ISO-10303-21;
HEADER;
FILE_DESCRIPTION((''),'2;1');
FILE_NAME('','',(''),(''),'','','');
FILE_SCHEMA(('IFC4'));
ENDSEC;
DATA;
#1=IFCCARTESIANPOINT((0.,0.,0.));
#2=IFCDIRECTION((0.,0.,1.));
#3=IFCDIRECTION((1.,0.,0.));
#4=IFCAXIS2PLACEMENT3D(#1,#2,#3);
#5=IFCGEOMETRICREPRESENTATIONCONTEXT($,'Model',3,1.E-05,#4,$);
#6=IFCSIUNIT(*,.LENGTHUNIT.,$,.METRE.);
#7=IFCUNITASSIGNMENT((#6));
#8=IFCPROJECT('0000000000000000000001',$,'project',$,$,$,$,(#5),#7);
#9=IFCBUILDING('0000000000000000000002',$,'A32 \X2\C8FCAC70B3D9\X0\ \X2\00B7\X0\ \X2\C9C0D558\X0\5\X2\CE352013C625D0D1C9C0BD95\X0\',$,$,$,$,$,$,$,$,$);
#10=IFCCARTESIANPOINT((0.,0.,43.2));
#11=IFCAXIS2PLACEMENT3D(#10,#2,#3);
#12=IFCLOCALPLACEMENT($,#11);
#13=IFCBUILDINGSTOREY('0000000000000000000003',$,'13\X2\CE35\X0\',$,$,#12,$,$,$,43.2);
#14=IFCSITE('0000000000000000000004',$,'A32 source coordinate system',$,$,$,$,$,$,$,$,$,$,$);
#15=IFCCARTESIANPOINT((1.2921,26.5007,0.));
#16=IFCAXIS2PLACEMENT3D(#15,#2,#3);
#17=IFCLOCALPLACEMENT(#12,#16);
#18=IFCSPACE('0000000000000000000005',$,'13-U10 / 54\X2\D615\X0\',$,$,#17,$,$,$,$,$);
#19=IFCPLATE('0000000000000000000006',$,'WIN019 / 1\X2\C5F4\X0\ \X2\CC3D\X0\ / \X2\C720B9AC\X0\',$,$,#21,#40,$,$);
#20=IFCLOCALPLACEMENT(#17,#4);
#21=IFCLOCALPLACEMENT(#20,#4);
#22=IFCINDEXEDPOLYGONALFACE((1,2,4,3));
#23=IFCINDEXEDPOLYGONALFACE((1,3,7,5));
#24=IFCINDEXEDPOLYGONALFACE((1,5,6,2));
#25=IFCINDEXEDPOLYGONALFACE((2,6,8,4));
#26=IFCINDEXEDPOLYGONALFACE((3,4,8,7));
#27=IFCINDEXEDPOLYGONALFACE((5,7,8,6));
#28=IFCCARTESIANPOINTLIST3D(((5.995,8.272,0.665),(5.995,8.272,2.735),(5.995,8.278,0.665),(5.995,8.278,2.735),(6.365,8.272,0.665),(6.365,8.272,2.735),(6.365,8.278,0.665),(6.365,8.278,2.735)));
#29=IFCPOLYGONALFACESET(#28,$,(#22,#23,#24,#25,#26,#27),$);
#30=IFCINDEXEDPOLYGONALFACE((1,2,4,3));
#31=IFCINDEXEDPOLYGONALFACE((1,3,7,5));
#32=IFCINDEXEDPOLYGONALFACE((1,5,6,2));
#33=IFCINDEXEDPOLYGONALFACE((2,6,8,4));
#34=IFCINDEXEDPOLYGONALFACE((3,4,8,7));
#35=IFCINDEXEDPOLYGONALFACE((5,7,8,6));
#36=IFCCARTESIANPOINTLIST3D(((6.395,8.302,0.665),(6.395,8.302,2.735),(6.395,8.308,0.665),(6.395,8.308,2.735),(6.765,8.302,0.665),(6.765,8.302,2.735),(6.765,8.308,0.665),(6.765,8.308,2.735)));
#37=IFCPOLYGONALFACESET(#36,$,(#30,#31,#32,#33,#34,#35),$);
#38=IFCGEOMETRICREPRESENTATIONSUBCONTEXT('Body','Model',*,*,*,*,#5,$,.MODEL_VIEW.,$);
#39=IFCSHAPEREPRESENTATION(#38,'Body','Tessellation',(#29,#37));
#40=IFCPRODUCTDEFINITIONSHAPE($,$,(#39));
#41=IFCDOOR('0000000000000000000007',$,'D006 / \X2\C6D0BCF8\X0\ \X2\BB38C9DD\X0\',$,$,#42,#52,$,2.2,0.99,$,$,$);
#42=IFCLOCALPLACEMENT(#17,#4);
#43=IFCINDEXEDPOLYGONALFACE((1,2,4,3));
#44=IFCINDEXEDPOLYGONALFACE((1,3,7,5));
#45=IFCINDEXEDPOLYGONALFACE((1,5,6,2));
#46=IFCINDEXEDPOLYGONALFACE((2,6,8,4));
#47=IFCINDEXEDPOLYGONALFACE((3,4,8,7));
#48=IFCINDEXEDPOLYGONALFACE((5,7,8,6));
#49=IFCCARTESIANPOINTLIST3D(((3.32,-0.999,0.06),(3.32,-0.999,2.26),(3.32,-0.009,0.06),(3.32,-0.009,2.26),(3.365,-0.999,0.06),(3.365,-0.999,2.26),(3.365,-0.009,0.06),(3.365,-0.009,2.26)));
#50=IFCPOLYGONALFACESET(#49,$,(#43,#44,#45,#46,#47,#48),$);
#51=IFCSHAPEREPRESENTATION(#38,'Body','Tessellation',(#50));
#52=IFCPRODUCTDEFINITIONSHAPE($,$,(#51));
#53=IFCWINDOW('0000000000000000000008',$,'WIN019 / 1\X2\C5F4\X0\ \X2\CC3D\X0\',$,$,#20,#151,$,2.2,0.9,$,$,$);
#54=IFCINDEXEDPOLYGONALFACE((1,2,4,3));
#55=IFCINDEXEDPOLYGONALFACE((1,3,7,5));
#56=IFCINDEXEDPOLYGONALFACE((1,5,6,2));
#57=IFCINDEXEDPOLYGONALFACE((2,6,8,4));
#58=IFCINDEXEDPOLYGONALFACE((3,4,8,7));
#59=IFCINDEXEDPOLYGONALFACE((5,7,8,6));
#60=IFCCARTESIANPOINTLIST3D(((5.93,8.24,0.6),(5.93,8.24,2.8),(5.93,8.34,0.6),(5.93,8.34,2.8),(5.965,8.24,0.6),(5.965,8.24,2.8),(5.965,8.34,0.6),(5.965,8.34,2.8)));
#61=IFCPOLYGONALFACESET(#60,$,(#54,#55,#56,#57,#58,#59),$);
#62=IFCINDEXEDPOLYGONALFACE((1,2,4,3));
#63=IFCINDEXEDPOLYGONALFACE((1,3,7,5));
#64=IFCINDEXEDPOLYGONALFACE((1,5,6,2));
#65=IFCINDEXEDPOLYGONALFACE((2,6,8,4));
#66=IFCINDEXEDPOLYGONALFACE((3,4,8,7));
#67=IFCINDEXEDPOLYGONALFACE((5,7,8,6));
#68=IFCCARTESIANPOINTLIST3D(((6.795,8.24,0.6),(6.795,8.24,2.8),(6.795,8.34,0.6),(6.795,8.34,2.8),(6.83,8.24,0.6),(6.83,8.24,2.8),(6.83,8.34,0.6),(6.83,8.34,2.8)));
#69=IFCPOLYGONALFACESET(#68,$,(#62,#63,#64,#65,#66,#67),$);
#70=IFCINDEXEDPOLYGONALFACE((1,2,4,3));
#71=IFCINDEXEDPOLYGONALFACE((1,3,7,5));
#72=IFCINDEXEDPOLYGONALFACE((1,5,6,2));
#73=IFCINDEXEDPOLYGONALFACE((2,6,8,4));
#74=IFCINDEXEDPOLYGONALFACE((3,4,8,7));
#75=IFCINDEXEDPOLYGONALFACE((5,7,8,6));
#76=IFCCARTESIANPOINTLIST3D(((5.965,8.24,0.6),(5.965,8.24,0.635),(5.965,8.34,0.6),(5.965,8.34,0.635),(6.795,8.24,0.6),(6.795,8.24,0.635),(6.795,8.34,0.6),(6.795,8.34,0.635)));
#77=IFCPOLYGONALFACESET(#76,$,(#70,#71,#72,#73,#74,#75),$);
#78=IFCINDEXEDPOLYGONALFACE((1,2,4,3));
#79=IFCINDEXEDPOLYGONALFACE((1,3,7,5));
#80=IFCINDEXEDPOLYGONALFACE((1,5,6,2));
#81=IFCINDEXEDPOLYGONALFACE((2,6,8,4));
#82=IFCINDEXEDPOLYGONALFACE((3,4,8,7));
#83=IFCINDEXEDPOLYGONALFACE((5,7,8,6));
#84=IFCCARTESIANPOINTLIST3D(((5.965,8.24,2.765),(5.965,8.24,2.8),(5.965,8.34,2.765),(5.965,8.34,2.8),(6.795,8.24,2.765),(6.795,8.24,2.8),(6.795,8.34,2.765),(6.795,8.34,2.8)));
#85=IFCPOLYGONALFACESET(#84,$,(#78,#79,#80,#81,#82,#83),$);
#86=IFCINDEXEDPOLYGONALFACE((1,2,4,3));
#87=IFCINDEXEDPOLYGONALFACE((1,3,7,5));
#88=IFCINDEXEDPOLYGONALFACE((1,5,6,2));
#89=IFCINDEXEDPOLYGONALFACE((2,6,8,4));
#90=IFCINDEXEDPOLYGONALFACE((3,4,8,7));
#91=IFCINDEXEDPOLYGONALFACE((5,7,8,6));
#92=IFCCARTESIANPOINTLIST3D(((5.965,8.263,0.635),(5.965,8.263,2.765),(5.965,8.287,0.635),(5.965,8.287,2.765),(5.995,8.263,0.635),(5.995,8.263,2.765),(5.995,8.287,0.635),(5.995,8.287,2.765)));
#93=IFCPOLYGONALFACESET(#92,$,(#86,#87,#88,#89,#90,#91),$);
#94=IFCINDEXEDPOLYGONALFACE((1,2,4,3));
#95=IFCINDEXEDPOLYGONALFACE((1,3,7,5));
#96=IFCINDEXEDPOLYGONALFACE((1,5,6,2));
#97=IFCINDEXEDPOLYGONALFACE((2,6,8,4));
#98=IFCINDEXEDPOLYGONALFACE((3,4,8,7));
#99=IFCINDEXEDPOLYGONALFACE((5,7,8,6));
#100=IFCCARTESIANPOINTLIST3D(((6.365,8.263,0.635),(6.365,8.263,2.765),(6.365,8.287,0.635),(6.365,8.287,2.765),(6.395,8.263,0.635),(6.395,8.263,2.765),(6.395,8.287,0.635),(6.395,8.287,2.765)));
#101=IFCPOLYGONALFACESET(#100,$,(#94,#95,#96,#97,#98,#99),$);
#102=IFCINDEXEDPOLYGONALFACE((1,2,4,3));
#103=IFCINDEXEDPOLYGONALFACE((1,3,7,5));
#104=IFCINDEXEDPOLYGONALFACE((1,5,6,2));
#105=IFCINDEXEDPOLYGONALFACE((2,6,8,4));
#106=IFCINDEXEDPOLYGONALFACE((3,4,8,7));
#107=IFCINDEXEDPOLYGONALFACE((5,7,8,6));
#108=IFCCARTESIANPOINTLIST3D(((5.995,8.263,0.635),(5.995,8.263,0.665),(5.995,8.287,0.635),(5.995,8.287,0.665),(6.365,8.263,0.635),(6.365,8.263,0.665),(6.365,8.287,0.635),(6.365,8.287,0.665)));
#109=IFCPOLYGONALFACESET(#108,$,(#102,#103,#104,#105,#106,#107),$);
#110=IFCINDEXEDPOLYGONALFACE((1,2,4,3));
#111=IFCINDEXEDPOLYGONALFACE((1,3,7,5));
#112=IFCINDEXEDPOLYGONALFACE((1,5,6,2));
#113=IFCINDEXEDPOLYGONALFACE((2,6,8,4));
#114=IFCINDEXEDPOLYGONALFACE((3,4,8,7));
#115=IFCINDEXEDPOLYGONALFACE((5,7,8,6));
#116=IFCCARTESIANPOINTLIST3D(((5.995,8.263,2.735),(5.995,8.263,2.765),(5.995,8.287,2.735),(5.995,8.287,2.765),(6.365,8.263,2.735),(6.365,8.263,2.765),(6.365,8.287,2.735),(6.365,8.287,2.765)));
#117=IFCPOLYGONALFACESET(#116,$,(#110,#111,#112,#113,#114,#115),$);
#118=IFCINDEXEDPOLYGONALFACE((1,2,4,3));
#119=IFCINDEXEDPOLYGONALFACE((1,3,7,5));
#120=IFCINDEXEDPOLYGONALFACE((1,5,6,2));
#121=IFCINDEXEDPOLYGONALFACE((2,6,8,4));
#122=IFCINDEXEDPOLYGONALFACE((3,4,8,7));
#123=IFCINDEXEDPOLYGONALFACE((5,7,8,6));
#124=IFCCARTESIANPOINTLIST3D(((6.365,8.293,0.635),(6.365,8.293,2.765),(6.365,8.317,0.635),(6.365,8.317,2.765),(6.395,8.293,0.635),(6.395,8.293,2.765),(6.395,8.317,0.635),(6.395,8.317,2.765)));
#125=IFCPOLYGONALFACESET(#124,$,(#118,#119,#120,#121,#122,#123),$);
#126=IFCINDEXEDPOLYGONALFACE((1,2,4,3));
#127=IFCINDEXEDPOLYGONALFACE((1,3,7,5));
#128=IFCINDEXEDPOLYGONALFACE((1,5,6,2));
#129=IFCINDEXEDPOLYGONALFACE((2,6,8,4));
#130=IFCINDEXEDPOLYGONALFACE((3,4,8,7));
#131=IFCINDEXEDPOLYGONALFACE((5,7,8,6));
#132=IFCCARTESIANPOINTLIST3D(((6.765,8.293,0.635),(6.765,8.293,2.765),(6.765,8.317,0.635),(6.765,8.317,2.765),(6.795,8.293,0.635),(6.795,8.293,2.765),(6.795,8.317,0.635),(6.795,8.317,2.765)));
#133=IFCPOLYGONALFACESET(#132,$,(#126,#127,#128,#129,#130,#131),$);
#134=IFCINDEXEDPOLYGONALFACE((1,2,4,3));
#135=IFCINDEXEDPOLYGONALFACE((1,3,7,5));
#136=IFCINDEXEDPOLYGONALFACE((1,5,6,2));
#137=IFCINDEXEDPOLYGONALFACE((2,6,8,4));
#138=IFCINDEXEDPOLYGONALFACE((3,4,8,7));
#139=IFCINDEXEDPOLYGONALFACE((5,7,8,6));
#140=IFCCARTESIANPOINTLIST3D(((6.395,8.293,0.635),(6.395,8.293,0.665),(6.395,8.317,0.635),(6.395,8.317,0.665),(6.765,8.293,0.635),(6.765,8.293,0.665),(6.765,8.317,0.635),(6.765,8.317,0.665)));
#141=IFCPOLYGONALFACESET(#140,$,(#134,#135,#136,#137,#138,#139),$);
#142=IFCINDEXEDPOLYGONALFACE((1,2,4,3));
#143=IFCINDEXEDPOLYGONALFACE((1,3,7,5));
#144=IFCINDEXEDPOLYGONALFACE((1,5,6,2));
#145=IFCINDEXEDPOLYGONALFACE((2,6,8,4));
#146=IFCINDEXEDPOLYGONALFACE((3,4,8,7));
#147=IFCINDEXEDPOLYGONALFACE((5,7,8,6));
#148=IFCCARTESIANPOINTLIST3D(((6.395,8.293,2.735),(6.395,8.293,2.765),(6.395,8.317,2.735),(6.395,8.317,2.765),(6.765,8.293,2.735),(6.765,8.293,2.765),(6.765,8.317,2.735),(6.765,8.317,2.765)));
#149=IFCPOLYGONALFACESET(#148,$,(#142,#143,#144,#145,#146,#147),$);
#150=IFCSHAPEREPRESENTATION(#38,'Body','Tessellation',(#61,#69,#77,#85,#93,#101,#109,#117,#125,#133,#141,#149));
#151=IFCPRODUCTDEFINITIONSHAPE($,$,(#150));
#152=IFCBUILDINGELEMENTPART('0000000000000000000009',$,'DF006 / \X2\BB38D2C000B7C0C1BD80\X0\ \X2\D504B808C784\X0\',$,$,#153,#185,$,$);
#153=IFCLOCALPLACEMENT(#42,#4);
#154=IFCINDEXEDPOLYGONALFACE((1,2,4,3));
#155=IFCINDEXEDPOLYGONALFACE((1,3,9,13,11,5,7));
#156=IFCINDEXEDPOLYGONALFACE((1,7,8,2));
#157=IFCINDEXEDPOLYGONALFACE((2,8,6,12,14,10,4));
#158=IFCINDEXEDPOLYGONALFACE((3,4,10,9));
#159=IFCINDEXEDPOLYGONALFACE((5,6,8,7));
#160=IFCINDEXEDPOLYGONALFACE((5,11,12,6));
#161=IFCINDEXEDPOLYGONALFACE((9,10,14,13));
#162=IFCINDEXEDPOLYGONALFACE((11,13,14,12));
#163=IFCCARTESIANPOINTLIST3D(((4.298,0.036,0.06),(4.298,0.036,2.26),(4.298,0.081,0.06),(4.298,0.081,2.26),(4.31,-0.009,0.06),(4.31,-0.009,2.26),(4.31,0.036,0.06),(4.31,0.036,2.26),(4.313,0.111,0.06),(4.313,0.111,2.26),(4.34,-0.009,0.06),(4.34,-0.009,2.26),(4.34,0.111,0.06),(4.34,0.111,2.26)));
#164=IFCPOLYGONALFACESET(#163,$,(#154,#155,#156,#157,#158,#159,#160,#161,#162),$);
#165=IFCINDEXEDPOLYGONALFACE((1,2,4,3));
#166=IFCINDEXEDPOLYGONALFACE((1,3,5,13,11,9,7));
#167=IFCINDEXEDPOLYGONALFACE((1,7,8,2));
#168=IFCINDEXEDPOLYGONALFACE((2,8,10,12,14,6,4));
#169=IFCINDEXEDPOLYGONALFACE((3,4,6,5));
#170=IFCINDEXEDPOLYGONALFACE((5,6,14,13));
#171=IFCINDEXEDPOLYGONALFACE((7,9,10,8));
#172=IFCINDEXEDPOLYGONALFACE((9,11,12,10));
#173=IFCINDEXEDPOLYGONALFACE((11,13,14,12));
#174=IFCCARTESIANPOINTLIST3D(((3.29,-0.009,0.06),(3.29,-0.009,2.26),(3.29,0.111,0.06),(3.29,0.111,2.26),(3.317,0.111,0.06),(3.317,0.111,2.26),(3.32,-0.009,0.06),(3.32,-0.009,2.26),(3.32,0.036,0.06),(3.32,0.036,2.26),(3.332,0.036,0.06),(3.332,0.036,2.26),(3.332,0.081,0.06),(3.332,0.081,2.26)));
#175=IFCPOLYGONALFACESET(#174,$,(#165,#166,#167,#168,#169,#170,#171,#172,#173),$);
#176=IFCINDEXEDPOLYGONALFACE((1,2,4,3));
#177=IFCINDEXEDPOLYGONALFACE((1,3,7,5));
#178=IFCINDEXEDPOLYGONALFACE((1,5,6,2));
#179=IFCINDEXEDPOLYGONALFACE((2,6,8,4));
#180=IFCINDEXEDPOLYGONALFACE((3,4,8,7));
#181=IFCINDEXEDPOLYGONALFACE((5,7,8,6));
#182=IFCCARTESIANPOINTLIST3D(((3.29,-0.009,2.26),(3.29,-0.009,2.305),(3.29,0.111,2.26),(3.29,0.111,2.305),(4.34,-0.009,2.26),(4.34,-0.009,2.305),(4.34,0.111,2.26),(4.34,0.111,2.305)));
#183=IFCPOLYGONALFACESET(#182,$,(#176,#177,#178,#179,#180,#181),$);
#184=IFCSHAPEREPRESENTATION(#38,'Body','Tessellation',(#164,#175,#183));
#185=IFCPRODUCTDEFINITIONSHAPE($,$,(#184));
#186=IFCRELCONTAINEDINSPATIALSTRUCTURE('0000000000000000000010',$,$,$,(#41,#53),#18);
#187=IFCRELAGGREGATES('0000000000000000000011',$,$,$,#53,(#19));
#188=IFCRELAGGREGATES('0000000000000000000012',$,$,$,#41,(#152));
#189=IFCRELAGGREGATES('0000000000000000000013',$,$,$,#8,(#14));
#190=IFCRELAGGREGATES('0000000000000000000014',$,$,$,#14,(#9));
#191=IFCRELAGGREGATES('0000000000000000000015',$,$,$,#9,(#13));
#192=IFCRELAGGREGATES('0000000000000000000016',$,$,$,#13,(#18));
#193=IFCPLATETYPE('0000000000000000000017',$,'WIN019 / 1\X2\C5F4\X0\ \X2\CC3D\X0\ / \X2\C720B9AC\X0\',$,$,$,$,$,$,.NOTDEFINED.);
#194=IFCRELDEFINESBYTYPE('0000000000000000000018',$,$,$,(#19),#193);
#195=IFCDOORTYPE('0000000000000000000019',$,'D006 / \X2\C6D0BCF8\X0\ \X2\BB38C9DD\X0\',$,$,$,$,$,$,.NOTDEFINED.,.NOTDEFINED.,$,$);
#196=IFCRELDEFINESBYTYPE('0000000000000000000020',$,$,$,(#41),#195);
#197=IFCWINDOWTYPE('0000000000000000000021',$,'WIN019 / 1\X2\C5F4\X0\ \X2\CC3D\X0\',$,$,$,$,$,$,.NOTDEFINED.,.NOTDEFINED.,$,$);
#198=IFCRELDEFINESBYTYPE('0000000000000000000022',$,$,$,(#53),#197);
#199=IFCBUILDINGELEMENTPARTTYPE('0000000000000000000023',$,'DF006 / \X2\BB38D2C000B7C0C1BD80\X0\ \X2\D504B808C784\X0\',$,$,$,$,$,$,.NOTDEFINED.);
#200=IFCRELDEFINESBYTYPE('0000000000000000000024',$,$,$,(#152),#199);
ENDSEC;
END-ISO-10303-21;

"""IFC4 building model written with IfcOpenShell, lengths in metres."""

from ifc_helpers import new_model, si_unit, frame, origin, origin_with_axes, place, context, subcontext, project, spatial, polyline, outline, extrude, source, transform, mapped, type_object, type_shapes, element, aggregate, save


model = new_model("IFC4")

# Units and contexts
model_context = context("Model", 3, precision=1e-05, world=origin_with_axes())
body_context = subcontext(model_context, "Body", "Model", "MODEL_VIEW")
ifc_project = project(units=[si_unit("LENGTHUNIT", "METRE")], contexts=[model_context])

# Plate
storey_placement = place(None, frame((0.0, 0.0, 43.2), z_axis=(0.0, 0.0, 1.0), x_axis=(1.0, 0.0, 0.0)))
space_placement = place(storey_placement, frame((1.2921, 26.5007, 0.0), z_axis=(0.0, 0.0, 1.0), x_axis=(1.0, 0.0, 0.0)))
plate_type_1 = type_object("IfcPlateType", Name="WIN019 / 1열 창 / 유리", PredefinedType="NOTDEFINED")
shared_shape_1 = source(origin(), body_context, "Body", "SweptSolid", [
    extrude(outline(polyline([(5.995, 8.272), (5.995, 8.278), (6.365, 8.278), (6.365, 8.272), (5.995, 8.272)])), frame((0.0, 0.0, 0.665)), (0.0, 0.0, 1.0), 2.07),
    extrude(outline(polyline([(6.395, 8.302), (6.395, 8.308), (6.765, 8.308), (6.765, 8.302), (6.395, 8.302)])), frame((0.0, 0.0, 0.665)), (0.0, 0.0, 1.0), 2.07),
])
type_shapes(plate_type_1, [shared_shape_1])
window_1_placement = place(space_placement, origin_with_axes())
plate_1_placement = place(window_1_placement, origin_with_axes())
plate_1 = element("IfcPlate", 1, at=plate_1_placement, type_object=plate_type_1, Name="WIN019 / 1열 창 / 유리", context=body_context, shape_type="MappedRepresentation", body=[
    mapped(shared_shape_1, transform((0.0, 0.0, 0.0), scale=1.0)),
])

# Site, building, storey, space
site = spatial("IfcSite", under=ifc_project, Name="A32 source coordinate system")
building = spatial("IfcBuilding", under=site, Name="A32 주거동 · 지하5층–옥탑지붕")
storey = spatial("IfcBuildingStorey", under=building, at=storey_placement, Name="13층", Elevation=43.2)
space = spatial("IfcSpace", under=storey, at=space_placement, Name="13-U10 / 54형")

# Door
door_type_1 = type_object("IfcDoorType", Name="D006 / 원본 문짝", OperationType="NOTDEFINED", PredefinedType="NOTDEFINED")
shared_shape_2 = source(origin(), body_context, "Body", "SweptSolid", [
    extrude(outline(polyline([(3.365, -0.999), (3.32, -0.999), (3.32, -0.009), (3.365, -0.009), (3.365, -0.999)])), frame((0.0, 0.0, 0.06)), (0.0, 0.0, 1.0), 2.2),
])
type_shapes(door_type_1, [shared_shape_2])
door_1_placement = place(space_placement, origin_with_axes())
door_1 = element("IfcDoor", 2, at=door_1_placement, inside=space, type_object=door_type_1, Name="D006 / 원본 문짝", OverallHeight=2.2, OverallWidth=0.99, context=body_context, shape_type="MappedRepresentation", body=[
    mapped(shared_shape_2, transform((0.0, 0.0, 0.0), scale=1.0)),
])

# Window
window_type_1 = type_object("IfcWindowType", Name="WIN019 / 1열 창", PartitioningType="NOTDEFINED", PredefinedType="NOTDEFINED")
shared_shape_3 = source(origin(), body_context, "Body", "SweptSolid", [
    extrude(outline(polyline([(5.93, 8.24), (5.93, 8.34), (5.965, 8.34), (5.965, 8.24), (5.93, 8.24)])), frame((0.0, 0.0, 0.6)), (0.0, 0.0, 1.0), 2.2),
    extrude(outline(polyline([(6.795, 8.24), (6.795, 8.34), (6.83, 8.34), (6.83, 8.24), (6.795, 8.24)])), frame((0.0, 0.0, 0.6)), (0.0, 0.0, 1.0), 2.2),
    extrude(outline(polyline([(5.965, 8.24), (5.965, 8.34), (6.795, 8.34), (6.795, 8.24), (5.965, 8.24)])), frame((0.0, 0.0, 0.6)), (0.0, 0.0, 1.0), 0.035),
    extrude(outline(polyline([(5.965, 8.24), (5.965, 8.34), (6.795, 8.34), (6.795, 8.24), (5.965, 8.24)])), frame((0.0, 0.0, 2.765)), (0.0, 0.0, 1.0), 0.035),
    extrude(outline(polyline([(5.965, 8.263), (5.965, 8.287), (5.995, 8.287), (5.995, 8.263), (5.965, 8.263)])), frame((0.0, 0.0, 0.635)), (0.0, 0.0, 1.0), 2.13),
    extrude(outline(polyline([(6.365, 8.263), (6.365, 8.287), (6.395, 8.287), (6.395, 8.263), (6.365, 8.263)])), frame((0.0, 0.0, 0.635)), (0.0, 0.0, 1.0), 2.13),
    extrude(outline(polyline([(5.995, 8.263), (5.995, 8.287), (6.365, 8.287), (6.365, 8.263), (5.995, 8.263)])), frame((0.0, 0.0, 0.635)), (0.0, 0.0, 1.0), 0.03),
    extrude(outline(polyline([(5.995, 8.263), (5.995, 8.287), (6.365, 8.287), (6.365, 8.263), (5.995, 8.263)])), frame((0.0, 0.0, 2.735)), (0.0, 0.0, 1.0), 0.03),
    extrude(outline(polyline([(6.365, 8.293), (6.365, 8.317), (6.395, 8.317), (6.395, 8.293), (6.365, 8.293)])), frame((0.0, 0.0, 0.635)), (0.0, 0.0, 1.0), 2.13),
    extrude(outline(polyline([(6.765, 8.293), (6.765, 8.317), (6.795, 8.317), (6.795, 8.293), (6.765, 8.293)])), frame((0.0, 0.0, 0.635)), (0.0, 0.0, 1.0), 2.13),
    extrude(outline(polyline([(6.395, 8.293), (6.395, 8.317), (6.765, 8.317), (6.765, 8.293), (6.395, 8.293)])), frame((0.0, 0.0, 0.635)), (0.0, 0.0, 1.0), 0.03),
    extrude(outline(polyline([(6.395, 8.293), (6.395, 8.317), (6.765, 8.317), (6.765, 8.293), (6.395, 8.293)])), frame((0.0, 0.0, 2.735)), (0.0, 0.0, 1.0), 0.03),
])
type_shapes(window_type_1, [shared_shape_3])
window_1 = element("IfcWindow", 3, at=window_1_placement, inside=space, type_object=window_type_1, Name="WIN019 / 1열 창", OverallHeight=2.2, OverallWidth=0.9, context=body_context, shape_type="MappedRepresentation", body=[
    mapped(shared_shape_3, transform((0.0, 0.0, 0.0), scale=1.0)),
])
aggregate(window_1, [plate_1])

# Building element part
building_element_part_type_1 = type_object("IfcBuildingElementPartType", Name="DF006 / 문틀·상부 프레임", PredefinedType="NOTDEFINED")
shared_shape_4 = source(origin(), body_context, "Body", "SweptSolid", [
    extrude(outline(polyline([(4.31, -0.009), (4.31, 0.036), (4.298, 0.036), (4.298, 0.081), (4.313, 0.111), (4.34, 0.111), (4.34, -0.009), (4.31, -0.009)])), frame((0.0, 0.0, 0.06)), (0.0, 0.0, 1.0), 2.2),
    extrude(outline(polyline([(3.29, 0.111), (3.317, 0.111), (3.332, 0.081), (3.332, 0.036), (3.32, 0.036), (3.32, -0.009), (3.29, -0.009), (3.29, 0.111)])), frame((0.0, 0.0, 0.06)), (0.0, 0.0, 1.0), 2.2),
    extrude(outline(polyline([(3.29, -0.009), (3.29, 0.111), (4.34, 0.111), (4.34, -0.009), (3.29, -0.009)])), frame((0.0, 0.0, 2.26)), (0.0, 0.0, 1.0), 0.045),
])
type_shapes(building_element_part_type_1, [shared_shape_4])
building_element_part_1_placement = place(door_1_placement, origin_with_axes())
building_element_part_1 = element("IfcBuildingElementPart", 4, at=building_element_part_1_placement, type_object=building_element_part_type_1, Name="DF006 / 문틀·상부 프레임", context=body_context, shape_type="MappedRepresentation", body=[
    mapped(shared_shape_4, transform((0.0, 0.0, 0.0), scale=1.0)),
])
aggregate(door_1, [building_element_part_1])

save(model, "model.ifc")
